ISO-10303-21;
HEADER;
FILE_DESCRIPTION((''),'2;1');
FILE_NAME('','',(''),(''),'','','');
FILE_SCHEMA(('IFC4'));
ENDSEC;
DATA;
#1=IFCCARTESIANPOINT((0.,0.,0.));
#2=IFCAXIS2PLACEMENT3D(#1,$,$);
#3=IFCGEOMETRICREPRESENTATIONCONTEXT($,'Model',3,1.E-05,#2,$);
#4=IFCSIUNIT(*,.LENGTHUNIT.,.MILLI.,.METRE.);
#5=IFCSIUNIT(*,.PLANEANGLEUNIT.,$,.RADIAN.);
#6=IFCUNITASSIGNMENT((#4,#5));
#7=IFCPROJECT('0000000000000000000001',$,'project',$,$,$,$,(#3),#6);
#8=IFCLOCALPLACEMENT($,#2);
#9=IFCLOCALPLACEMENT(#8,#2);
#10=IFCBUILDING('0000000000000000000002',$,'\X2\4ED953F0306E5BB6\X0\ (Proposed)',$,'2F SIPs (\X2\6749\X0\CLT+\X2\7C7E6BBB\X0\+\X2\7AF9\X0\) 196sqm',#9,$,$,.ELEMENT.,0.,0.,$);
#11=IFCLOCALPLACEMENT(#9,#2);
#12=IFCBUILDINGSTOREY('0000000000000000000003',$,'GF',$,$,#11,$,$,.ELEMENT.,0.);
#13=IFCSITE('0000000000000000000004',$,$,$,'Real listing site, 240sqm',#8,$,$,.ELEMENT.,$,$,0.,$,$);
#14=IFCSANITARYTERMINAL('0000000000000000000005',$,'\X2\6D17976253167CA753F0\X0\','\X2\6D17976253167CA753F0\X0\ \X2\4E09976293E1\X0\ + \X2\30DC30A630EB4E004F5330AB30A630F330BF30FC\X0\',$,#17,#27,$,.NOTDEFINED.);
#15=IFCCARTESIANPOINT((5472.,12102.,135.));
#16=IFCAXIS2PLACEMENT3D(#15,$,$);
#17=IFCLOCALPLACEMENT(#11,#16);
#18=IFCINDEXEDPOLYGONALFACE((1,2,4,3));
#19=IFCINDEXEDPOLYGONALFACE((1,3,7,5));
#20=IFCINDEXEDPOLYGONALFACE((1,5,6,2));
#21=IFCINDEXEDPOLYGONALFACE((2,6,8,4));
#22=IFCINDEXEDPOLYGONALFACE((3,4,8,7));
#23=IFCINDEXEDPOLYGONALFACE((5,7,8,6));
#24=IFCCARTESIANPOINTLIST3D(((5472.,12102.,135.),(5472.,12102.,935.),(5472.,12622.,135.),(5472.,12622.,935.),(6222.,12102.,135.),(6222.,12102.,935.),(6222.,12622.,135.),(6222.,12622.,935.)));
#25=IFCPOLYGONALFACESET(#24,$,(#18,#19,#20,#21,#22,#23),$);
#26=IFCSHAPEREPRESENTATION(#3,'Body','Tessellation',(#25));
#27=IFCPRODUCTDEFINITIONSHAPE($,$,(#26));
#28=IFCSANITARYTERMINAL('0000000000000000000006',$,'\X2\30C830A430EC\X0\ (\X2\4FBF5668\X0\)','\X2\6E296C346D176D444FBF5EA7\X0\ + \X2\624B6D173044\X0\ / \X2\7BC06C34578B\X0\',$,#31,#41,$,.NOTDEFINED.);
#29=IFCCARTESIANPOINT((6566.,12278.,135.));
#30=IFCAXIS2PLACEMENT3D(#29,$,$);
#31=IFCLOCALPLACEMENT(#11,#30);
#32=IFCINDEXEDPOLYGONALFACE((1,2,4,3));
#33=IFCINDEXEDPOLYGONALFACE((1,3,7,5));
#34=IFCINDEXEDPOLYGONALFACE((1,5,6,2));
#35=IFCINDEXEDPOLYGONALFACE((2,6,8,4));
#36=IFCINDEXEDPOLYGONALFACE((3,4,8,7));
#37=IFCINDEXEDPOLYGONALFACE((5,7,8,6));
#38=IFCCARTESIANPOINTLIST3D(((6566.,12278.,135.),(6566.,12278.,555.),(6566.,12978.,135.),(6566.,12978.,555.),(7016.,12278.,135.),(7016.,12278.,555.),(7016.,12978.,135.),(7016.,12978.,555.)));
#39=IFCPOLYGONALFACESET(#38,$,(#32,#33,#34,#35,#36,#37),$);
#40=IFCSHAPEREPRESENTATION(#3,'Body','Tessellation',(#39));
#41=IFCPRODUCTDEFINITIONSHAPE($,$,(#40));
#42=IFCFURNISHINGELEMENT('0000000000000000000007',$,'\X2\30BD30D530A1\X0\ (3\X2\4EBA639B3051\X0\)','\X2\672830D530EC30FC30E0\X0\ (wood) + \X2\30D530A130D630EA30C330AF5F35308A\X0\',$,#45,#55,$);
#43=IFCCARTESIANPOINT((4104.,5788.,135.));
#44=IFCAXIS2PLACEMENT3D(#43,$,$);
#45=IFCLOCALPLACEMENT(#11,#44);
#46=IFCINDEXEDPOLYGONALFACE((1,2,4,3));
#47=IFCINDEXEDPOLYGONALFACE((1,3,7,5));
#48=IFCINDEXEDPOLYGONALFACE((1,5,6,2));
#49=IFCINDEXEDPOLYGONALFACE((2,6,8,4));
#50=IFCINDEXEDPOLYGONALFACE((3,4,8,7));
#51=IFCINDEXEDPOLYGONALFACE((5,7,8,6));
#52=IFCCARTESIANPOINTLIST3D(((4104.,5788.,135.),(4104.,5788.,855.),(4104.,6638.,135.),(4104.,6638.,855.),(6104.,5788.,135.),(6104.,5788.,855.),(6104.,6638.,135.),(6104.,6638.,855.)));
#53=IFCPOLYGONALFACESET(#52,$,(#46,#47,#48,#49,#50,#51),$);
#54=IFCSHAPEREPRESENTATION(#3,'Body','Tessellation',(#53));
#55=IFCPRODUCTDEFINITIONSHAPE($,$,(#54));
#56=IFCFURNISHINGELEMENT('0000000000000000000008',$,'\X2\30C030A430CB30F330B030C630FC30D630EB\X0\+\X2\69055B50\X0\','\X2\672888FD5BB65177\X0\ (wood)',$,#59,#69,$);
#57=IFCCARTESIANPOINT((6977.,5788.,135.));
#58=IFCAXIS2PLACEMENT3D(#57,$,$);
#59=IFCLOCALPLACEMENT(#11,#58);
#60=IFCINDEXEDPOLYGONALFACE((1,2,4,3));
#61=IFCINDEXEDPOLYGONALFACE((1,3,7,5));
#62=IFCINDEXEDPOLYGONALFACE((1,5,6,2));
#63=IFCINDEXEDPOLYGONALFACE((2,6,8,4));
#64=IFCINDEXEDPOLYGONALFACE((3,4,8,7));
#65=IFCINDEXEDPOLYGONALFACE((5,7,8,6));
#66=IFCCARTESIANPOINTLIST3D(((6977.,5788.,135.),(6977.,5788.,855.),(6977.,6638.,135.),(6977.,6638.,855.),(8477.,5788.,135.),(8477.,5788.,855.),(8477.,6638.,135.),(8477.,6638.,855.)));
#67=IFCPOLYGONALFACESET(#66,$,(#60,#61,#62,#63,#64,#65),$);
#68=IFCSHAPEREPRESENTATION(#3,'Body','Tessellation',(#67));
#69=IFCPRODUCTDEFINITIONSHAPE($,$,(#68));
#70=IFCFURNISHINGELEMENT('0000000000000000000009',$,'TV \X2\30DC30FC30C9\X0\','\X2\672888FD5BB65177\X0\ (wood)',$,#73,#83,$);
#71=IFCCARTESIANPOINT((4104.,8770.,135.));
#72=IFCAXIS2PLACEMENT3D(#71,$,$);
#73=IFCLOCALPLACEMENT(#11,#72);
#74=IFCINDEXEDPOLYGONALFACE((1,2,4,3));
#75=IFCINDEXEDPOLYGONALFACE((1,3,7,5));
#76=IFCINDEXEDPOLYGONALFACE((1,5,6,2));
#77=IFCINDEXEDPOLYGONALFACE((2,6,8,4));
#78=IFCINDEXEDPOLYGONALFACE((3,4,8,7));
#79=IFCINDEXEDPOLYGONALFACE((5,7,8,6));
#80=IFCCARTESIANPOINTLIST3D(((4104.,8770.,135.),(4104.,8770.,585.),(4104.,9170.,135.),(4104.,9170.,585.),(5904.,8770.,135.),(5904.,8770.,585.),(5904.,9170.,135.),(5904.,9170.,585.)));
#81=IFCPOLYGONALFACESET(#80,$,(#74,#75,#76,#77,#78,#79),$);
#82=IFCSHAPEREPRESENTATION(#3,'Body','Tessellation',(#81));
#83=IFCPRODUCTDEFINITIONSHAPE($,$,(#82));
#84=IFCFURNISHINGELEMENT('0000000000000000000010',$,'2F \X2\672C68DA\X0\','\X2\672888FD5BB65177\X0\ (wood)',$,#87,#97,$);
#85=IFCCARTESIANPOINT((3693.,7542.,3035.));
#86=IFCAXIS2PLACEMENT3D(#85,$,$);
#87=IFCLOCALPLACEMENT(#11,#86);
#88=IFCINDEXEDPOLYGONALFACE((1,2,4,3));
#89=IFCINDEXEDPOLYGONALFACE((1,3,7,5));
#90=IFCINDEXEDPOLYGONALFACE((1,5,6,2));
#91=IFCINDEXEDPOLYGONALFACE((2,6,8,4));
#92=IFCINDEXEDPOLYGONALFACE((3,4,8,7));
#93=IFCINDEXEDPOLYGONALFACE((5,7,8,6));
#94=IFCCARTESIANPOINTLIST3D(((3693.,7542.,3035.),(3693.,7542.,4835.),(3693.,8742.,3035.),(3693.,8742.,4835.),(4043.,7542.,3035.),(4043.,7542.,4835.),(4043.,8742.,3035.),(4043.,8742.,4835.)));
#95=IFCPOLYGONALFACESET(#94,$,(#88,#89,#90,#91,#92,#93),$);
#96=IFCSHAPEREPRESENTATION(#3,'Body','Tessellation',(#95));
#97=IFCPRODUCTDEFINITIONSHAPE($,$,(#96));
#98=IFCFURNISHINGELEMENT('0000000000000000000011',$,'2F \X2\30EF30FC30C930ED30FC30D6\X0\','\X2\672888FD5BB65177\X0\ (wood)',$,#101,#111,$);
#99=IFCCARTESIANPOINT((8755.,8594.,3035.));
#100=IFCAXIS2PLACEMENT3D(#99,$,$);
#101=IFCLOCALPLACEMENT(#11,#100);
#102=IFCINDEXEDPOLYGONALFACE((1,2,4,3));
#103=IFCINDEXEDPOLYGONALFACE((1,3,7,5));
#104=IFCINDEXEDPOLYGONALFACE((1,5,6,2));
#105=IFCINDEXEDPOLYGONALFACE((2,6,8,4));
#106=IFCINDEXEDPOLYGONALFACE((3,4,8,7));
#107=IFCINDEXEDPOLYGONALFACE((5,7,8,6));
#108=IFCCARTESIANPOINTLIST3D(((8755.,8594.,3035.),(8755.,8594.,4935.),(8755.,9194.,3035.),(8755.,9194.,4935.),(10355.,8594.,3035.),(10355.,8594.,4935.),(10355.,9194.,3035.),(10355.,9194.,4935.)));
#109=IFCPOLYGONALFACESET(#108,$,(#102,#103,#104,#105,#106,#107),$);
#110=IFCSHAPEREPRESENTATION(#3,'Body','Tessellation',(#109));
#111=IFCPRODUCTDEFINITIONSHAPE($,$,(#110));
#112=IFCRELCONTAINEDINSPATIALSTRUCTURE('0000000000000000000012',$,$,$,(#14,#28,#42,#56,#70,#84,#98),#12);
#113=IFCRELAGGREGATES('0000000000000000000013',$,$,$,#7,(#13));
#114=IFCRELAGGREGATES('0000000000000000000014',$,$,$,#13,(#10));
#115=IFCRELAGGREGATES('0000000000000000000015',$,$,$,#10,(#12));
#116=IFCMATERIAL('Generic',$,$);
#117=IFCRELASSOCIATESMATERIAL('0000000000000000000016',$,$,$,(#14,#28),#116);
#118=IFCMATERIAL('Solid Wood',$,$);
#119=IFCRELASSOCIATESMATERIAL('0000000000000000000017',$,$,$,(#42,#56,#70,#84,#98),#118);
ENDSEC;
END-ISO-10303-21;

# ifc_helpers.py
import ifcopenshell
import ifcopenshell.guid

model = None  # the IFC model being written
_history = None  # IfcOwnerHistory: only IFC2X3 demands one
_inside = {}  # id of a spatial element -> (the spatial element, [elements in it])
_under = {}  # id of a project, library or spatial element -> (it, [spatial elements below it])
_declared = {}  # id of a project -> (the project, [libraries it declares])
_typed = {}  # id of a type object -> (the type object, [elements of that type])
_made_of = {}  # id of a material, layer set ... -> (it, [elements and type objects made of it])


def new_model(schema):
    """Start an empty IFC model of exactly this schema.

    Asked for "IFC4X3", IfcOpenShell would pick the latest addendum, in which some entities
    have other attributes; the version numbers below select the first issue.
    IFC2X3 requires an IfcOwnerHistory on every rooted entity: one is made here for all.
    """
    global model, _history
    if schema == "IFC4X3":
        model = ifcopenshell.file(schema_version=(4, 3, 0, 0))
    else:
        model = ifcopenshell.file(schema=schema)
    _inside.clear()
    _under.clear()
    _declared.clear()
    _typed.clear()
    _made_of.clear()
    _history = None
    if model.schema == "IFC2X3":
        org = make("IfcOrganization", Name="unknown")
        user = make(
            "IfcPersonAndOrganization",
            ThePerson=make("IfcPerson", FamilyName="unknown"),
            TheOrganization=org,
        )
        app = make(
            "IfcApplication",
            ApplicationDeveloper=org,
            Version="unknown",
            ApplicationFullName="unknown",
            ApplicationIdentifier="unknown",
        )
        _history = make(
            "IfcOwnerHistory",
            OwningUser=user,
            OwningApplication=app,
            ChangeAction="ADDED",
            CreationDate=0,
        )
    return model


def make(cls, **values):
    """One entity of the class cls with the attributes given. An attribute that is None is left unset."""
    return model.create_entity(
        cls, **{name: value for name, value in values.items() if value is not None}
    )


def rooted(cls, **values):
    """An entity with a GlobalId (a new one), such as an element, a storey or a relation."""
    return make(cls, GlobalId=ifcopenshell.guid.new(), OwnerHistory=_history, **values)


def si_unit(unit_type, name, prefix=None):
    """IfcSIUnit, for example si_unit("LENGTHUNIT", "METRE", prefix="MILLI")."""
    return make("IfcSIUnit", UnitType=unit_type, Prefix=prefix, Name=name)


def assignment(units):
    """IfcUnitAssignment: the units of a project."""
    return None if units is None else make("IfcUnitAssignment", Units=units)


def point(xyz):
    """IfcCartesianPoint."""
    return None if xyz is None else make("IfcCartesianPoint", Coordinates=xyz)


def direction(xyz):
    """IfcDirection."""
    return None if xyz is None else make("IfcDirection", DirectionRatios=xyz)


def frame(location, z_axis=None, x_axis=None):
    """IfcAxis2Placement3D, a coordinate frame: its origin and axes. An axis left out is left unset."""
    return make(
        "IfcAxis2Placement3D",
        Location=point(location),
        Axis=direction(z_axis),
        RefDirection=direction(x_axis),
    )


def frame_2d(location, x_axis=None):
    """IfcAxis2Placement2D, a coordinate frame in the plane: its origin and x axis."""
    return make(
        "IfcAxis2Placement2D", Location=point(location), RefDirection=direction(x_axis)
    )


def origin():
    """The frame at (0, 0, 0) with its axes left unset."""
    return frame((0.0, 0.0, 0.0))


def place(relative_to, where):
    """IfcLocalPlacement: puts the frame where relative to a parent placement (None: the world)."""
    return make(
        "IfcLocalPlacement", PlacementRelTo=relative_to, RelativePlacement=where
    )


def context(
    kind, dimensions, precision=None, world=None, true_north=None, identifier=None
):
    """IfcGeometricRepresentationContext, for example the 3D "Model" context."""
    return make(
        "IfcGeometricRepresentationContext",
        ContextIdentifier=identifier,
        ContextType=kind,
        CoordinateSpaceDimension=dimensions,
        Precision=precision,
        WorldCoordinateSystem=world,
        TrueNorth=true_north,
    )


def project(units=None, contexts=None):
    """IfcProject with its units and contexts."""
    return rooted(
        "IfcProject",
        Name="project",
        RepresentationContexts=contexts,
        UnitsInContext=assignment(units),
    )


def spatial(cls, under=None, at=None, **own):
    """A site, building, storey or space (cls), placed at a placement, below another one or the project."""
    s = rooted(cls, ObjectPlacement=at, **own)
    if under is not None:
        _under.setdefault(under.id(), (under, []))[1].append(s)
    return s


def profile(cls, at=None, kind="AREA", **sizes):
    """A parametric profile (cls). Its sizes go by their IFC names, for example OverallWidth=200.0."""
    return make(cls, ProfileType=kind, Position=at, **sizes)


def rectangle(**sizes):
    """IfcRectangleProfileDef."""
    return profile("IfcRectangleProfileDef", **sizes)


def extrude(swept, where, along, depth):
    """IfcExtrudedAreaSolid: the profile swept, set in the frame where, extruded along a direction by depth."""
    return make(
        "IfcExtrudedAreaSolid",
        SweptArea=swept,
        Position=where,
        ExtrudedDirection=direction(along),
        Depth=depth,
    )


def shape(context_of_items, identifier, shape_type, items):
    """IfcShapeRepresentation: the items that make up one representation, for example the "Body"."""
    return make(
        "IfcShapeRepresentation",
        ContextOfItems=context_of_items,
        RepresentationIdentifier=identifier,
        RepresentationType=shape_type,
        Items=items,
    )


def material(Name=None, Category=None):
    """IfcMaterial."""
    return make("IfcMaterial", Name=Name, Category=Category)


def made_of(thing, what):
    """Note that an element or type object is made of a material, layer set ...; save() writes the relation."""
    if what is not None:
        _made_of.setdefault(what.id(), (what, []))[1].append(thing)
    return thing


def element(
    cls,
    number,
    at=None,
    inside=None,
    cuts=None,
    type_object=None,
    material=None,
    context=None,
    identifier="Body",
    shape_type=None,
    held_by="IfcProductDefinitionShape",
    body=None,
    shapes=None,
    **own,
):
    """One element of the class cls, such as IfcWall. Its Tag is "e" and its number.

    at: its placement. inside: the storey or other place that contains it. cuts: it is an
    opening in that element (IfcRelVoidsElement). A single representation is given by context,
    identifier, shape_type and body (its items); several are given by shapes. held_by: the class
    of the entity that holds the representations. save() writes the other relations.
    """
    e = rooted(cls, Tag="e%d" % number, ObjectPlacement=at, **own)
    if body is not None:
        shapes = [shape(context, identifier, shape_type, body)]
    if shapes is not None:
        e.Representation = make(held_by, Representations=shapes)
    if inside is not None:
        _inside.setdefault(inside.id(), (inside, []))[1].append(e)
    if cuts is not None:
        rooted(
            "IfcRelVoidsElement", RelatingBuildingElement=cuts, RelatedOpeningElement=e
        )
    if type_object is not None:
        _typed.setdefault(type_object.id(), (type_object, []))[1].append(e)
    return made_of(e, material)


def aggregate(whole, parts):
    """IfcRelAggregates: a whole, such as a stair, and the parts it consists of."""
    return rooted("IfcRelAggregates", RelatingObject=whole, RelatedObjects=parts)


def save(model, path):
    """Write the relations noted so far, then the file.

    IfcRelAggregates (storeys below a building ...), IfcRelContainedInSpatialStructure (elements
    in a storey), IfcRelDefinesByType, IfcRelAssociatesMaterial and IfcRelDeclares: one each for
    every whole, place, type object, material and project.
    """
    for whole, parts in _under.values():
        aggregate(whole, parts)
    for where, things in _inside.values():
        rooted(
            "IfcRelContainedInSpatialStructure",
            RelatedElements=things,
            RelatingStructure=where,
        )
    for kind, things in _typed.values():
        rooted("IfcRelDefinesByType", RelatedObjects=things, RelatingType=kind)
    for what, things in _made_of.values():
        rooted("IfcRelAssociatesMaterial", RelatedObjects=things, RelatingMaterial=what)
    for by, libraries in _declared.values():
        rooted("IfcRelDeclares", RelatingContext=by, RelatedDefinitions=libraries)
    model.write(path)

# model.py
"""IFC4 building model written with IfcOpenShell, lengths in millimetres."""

from ifc_helpers import new_model, si_unit, frame, frame_2d, origin, place, context, project, spatial, rectangle, extrude, material, element, save


model = new_model("IFC4")

# Units and contexts
model_context = context("Model", 3, precision=1e-05, world=origin())
ifc_project = project(units=[si_unit("LENGTHUNIT", "METRE", prefix="MILLI"), si_unit("PLANEANGLEUNIT", "RADIAN")], contexts=[model_context])

# Site, building, storey
site_placement = place(None, origin())
site = spatial("IfcSite", under=ifc_project, at=site_placement, ObjectType="Real listing site, 240sqm", CompositionType="ELEMENT", RefElevation=0.0)
building_placement = place(site_placement, origin())
building = spatial("IfcBuilding", under=site, at=building_placement, Name="仙台の家 (Proposed)", ObjectType="2F SIPs (杉CLT+籾殻+竹) 196sqm", CompositionType="ELEMENT", ElevationOfRefHeight=0.0, ElevationOfTerrain=0.0)
storey_placement = place(building_placement, origin())
storey = spatial("IfcBuildingStorey", under=building, at=storey_placement, Name="GF", CompositionType="ELEMENT", Elevation=0.0)

# Shared definitions
ifc_material_1 = material(Name="Generic")

# Shared definitions
ifc_material_2 = material(Name="Solid Wood")

# Sanitary terminals
sanitary_terminal_1_placement = place(storey_placement, frame((5472.0, 12102.0, 135.0)))
element("IfcSanitaryTerminal", 1, at=sanitary_terminal_1_placement, inside=storey, material=ifc_material_1, Name="洗面化粧台", Description="洗面化粧台 三面鏡 + ボウル一体カウンター", PredefinedType="NOTDEFINED", context=model_context, shape_type="SweptSolid", body=[
    extrude(rectangle(XDim=750.0, YDim=520.0, at=frame_2d((375.0, 260.0))), frame((5472.0, 12102.0, 135.0)), (0.0, 0.0, 1.0), 800.0),
])
sanitary_terminal_2_placement = place(storey_placement, frame((6566.0, 12278.0, 135.0)))
element("IfcSanitaryTerminal", 2, at=sanitary_terminal_2_placement, inside=storey, material=ifc_material_1, Name="トイレ (便器)", Description="温水洗浄便座 + 手洗い / 節水型", PredefinedType="NOTDEFINED", context=model_context, shape_type="SweptSolid", body=[
    extrude(rectangle(XDim=450.0, YDim=700.0, at=frame_2d((225.0, 350.0))), frame((6566.0, 12278.0, 135.0)), (0.0, 0.0, 1.0), 420.0),
])

# Furnishing elements
furnishing_1_placement = place(storey_placement, frame((4104.0, 5788.0, 135.0)))
element("IfcFurnishingElement", 3, at=furnishing_1_placement, inside=storey, material=ifc_material_2, Name="ソファ (3人掛け)", Description="木フレーム (wood) + ファブリック張り", context=model_context, shape_type="SweptSolid", body=[
    extrude(rectangle(XDim=2000.0, YDim=850.0, at=frame_2d((1000.0, 425.0))), frame((4104.0, 5788.0, 135.0)), (0.0, 0.0, 1.0), 720.0),
])
furnishing_2_placement = place(storey_placement, frame((6977.0, 5788.0, 135.0)))
element("IfcFurnishingElement", 4, at=furnishing_2_placement, inside=storey, material=ifc_material_2, Name="ダイニングテーブル+椅子", Description="木製家具 (wood)", context=model_context, shape_type="SweptSolid", body=[
    extrude(rectangle(XDim=1500.0, YDim=850.0, at=frame_2d((750.0, 425.0))), frame((6977.0, 5788.0, 135.0)), (0.0, 0.0, 1.0), 720.0),
])
furnishing_3_placement = place(storey_placement, frame((4104.0, 8770.0, 135.0)))
element("IfcFurnishingElement", 5, at=furnishing_3_placement, inside=storey, material=ifc_material_2, Name="TV ボード", Description="木製家具 (wood)", context=model_context, shape_type="SweptSolid", body=[
    extrude(rectangle(XDim=1800.0, YDim=400.0, at=frame_2d((900.0, 200.0))), frame((4104.0, 8770.0, 135.0)), (0.0, 0.0, 1.0), 450.0),
])
furnishing_4_placement = place(storey_placement, frame((3693.0, 7542.0, 3035.0)))
element("IfcFurnishingElement", 6, at=furnishing_4_placement, inside=storey, material=ifc_material_2, Name="2F 本棚", Description="木製家具 (wood)", context=model_context, shape_type="SweptSolid", body=[
    extrude(rectangle(XDim=350.0, YDim=1200.0, at=frame_2d((175.0, 600.0))), frame((3693.0, 7542.0, 3035.0)), (0.0, 0.0, 1.0), 1800.0),
])
furnishing_5_placement = place(storey_placement, frame((8755.0, 8594.0, 3035.0)))
element("IfcFurnishingElement", 7, at=furnishing_5_placement, inside=storey, material=ifc_material_2, Name="2F ワードローブ", Description="木製家具 (wood)", context=model_context, shape_type="SweptSolid", body=[
    extrude(rectangle(XDim=1600.0, YDim=600.0, at=frame_2d((800.0, 300.0))), frame((8755.0, 8594.0, 3035.0)), (0.0, 0.0, 1.0), 1900.0),
])

save(model, "model.ifc")
